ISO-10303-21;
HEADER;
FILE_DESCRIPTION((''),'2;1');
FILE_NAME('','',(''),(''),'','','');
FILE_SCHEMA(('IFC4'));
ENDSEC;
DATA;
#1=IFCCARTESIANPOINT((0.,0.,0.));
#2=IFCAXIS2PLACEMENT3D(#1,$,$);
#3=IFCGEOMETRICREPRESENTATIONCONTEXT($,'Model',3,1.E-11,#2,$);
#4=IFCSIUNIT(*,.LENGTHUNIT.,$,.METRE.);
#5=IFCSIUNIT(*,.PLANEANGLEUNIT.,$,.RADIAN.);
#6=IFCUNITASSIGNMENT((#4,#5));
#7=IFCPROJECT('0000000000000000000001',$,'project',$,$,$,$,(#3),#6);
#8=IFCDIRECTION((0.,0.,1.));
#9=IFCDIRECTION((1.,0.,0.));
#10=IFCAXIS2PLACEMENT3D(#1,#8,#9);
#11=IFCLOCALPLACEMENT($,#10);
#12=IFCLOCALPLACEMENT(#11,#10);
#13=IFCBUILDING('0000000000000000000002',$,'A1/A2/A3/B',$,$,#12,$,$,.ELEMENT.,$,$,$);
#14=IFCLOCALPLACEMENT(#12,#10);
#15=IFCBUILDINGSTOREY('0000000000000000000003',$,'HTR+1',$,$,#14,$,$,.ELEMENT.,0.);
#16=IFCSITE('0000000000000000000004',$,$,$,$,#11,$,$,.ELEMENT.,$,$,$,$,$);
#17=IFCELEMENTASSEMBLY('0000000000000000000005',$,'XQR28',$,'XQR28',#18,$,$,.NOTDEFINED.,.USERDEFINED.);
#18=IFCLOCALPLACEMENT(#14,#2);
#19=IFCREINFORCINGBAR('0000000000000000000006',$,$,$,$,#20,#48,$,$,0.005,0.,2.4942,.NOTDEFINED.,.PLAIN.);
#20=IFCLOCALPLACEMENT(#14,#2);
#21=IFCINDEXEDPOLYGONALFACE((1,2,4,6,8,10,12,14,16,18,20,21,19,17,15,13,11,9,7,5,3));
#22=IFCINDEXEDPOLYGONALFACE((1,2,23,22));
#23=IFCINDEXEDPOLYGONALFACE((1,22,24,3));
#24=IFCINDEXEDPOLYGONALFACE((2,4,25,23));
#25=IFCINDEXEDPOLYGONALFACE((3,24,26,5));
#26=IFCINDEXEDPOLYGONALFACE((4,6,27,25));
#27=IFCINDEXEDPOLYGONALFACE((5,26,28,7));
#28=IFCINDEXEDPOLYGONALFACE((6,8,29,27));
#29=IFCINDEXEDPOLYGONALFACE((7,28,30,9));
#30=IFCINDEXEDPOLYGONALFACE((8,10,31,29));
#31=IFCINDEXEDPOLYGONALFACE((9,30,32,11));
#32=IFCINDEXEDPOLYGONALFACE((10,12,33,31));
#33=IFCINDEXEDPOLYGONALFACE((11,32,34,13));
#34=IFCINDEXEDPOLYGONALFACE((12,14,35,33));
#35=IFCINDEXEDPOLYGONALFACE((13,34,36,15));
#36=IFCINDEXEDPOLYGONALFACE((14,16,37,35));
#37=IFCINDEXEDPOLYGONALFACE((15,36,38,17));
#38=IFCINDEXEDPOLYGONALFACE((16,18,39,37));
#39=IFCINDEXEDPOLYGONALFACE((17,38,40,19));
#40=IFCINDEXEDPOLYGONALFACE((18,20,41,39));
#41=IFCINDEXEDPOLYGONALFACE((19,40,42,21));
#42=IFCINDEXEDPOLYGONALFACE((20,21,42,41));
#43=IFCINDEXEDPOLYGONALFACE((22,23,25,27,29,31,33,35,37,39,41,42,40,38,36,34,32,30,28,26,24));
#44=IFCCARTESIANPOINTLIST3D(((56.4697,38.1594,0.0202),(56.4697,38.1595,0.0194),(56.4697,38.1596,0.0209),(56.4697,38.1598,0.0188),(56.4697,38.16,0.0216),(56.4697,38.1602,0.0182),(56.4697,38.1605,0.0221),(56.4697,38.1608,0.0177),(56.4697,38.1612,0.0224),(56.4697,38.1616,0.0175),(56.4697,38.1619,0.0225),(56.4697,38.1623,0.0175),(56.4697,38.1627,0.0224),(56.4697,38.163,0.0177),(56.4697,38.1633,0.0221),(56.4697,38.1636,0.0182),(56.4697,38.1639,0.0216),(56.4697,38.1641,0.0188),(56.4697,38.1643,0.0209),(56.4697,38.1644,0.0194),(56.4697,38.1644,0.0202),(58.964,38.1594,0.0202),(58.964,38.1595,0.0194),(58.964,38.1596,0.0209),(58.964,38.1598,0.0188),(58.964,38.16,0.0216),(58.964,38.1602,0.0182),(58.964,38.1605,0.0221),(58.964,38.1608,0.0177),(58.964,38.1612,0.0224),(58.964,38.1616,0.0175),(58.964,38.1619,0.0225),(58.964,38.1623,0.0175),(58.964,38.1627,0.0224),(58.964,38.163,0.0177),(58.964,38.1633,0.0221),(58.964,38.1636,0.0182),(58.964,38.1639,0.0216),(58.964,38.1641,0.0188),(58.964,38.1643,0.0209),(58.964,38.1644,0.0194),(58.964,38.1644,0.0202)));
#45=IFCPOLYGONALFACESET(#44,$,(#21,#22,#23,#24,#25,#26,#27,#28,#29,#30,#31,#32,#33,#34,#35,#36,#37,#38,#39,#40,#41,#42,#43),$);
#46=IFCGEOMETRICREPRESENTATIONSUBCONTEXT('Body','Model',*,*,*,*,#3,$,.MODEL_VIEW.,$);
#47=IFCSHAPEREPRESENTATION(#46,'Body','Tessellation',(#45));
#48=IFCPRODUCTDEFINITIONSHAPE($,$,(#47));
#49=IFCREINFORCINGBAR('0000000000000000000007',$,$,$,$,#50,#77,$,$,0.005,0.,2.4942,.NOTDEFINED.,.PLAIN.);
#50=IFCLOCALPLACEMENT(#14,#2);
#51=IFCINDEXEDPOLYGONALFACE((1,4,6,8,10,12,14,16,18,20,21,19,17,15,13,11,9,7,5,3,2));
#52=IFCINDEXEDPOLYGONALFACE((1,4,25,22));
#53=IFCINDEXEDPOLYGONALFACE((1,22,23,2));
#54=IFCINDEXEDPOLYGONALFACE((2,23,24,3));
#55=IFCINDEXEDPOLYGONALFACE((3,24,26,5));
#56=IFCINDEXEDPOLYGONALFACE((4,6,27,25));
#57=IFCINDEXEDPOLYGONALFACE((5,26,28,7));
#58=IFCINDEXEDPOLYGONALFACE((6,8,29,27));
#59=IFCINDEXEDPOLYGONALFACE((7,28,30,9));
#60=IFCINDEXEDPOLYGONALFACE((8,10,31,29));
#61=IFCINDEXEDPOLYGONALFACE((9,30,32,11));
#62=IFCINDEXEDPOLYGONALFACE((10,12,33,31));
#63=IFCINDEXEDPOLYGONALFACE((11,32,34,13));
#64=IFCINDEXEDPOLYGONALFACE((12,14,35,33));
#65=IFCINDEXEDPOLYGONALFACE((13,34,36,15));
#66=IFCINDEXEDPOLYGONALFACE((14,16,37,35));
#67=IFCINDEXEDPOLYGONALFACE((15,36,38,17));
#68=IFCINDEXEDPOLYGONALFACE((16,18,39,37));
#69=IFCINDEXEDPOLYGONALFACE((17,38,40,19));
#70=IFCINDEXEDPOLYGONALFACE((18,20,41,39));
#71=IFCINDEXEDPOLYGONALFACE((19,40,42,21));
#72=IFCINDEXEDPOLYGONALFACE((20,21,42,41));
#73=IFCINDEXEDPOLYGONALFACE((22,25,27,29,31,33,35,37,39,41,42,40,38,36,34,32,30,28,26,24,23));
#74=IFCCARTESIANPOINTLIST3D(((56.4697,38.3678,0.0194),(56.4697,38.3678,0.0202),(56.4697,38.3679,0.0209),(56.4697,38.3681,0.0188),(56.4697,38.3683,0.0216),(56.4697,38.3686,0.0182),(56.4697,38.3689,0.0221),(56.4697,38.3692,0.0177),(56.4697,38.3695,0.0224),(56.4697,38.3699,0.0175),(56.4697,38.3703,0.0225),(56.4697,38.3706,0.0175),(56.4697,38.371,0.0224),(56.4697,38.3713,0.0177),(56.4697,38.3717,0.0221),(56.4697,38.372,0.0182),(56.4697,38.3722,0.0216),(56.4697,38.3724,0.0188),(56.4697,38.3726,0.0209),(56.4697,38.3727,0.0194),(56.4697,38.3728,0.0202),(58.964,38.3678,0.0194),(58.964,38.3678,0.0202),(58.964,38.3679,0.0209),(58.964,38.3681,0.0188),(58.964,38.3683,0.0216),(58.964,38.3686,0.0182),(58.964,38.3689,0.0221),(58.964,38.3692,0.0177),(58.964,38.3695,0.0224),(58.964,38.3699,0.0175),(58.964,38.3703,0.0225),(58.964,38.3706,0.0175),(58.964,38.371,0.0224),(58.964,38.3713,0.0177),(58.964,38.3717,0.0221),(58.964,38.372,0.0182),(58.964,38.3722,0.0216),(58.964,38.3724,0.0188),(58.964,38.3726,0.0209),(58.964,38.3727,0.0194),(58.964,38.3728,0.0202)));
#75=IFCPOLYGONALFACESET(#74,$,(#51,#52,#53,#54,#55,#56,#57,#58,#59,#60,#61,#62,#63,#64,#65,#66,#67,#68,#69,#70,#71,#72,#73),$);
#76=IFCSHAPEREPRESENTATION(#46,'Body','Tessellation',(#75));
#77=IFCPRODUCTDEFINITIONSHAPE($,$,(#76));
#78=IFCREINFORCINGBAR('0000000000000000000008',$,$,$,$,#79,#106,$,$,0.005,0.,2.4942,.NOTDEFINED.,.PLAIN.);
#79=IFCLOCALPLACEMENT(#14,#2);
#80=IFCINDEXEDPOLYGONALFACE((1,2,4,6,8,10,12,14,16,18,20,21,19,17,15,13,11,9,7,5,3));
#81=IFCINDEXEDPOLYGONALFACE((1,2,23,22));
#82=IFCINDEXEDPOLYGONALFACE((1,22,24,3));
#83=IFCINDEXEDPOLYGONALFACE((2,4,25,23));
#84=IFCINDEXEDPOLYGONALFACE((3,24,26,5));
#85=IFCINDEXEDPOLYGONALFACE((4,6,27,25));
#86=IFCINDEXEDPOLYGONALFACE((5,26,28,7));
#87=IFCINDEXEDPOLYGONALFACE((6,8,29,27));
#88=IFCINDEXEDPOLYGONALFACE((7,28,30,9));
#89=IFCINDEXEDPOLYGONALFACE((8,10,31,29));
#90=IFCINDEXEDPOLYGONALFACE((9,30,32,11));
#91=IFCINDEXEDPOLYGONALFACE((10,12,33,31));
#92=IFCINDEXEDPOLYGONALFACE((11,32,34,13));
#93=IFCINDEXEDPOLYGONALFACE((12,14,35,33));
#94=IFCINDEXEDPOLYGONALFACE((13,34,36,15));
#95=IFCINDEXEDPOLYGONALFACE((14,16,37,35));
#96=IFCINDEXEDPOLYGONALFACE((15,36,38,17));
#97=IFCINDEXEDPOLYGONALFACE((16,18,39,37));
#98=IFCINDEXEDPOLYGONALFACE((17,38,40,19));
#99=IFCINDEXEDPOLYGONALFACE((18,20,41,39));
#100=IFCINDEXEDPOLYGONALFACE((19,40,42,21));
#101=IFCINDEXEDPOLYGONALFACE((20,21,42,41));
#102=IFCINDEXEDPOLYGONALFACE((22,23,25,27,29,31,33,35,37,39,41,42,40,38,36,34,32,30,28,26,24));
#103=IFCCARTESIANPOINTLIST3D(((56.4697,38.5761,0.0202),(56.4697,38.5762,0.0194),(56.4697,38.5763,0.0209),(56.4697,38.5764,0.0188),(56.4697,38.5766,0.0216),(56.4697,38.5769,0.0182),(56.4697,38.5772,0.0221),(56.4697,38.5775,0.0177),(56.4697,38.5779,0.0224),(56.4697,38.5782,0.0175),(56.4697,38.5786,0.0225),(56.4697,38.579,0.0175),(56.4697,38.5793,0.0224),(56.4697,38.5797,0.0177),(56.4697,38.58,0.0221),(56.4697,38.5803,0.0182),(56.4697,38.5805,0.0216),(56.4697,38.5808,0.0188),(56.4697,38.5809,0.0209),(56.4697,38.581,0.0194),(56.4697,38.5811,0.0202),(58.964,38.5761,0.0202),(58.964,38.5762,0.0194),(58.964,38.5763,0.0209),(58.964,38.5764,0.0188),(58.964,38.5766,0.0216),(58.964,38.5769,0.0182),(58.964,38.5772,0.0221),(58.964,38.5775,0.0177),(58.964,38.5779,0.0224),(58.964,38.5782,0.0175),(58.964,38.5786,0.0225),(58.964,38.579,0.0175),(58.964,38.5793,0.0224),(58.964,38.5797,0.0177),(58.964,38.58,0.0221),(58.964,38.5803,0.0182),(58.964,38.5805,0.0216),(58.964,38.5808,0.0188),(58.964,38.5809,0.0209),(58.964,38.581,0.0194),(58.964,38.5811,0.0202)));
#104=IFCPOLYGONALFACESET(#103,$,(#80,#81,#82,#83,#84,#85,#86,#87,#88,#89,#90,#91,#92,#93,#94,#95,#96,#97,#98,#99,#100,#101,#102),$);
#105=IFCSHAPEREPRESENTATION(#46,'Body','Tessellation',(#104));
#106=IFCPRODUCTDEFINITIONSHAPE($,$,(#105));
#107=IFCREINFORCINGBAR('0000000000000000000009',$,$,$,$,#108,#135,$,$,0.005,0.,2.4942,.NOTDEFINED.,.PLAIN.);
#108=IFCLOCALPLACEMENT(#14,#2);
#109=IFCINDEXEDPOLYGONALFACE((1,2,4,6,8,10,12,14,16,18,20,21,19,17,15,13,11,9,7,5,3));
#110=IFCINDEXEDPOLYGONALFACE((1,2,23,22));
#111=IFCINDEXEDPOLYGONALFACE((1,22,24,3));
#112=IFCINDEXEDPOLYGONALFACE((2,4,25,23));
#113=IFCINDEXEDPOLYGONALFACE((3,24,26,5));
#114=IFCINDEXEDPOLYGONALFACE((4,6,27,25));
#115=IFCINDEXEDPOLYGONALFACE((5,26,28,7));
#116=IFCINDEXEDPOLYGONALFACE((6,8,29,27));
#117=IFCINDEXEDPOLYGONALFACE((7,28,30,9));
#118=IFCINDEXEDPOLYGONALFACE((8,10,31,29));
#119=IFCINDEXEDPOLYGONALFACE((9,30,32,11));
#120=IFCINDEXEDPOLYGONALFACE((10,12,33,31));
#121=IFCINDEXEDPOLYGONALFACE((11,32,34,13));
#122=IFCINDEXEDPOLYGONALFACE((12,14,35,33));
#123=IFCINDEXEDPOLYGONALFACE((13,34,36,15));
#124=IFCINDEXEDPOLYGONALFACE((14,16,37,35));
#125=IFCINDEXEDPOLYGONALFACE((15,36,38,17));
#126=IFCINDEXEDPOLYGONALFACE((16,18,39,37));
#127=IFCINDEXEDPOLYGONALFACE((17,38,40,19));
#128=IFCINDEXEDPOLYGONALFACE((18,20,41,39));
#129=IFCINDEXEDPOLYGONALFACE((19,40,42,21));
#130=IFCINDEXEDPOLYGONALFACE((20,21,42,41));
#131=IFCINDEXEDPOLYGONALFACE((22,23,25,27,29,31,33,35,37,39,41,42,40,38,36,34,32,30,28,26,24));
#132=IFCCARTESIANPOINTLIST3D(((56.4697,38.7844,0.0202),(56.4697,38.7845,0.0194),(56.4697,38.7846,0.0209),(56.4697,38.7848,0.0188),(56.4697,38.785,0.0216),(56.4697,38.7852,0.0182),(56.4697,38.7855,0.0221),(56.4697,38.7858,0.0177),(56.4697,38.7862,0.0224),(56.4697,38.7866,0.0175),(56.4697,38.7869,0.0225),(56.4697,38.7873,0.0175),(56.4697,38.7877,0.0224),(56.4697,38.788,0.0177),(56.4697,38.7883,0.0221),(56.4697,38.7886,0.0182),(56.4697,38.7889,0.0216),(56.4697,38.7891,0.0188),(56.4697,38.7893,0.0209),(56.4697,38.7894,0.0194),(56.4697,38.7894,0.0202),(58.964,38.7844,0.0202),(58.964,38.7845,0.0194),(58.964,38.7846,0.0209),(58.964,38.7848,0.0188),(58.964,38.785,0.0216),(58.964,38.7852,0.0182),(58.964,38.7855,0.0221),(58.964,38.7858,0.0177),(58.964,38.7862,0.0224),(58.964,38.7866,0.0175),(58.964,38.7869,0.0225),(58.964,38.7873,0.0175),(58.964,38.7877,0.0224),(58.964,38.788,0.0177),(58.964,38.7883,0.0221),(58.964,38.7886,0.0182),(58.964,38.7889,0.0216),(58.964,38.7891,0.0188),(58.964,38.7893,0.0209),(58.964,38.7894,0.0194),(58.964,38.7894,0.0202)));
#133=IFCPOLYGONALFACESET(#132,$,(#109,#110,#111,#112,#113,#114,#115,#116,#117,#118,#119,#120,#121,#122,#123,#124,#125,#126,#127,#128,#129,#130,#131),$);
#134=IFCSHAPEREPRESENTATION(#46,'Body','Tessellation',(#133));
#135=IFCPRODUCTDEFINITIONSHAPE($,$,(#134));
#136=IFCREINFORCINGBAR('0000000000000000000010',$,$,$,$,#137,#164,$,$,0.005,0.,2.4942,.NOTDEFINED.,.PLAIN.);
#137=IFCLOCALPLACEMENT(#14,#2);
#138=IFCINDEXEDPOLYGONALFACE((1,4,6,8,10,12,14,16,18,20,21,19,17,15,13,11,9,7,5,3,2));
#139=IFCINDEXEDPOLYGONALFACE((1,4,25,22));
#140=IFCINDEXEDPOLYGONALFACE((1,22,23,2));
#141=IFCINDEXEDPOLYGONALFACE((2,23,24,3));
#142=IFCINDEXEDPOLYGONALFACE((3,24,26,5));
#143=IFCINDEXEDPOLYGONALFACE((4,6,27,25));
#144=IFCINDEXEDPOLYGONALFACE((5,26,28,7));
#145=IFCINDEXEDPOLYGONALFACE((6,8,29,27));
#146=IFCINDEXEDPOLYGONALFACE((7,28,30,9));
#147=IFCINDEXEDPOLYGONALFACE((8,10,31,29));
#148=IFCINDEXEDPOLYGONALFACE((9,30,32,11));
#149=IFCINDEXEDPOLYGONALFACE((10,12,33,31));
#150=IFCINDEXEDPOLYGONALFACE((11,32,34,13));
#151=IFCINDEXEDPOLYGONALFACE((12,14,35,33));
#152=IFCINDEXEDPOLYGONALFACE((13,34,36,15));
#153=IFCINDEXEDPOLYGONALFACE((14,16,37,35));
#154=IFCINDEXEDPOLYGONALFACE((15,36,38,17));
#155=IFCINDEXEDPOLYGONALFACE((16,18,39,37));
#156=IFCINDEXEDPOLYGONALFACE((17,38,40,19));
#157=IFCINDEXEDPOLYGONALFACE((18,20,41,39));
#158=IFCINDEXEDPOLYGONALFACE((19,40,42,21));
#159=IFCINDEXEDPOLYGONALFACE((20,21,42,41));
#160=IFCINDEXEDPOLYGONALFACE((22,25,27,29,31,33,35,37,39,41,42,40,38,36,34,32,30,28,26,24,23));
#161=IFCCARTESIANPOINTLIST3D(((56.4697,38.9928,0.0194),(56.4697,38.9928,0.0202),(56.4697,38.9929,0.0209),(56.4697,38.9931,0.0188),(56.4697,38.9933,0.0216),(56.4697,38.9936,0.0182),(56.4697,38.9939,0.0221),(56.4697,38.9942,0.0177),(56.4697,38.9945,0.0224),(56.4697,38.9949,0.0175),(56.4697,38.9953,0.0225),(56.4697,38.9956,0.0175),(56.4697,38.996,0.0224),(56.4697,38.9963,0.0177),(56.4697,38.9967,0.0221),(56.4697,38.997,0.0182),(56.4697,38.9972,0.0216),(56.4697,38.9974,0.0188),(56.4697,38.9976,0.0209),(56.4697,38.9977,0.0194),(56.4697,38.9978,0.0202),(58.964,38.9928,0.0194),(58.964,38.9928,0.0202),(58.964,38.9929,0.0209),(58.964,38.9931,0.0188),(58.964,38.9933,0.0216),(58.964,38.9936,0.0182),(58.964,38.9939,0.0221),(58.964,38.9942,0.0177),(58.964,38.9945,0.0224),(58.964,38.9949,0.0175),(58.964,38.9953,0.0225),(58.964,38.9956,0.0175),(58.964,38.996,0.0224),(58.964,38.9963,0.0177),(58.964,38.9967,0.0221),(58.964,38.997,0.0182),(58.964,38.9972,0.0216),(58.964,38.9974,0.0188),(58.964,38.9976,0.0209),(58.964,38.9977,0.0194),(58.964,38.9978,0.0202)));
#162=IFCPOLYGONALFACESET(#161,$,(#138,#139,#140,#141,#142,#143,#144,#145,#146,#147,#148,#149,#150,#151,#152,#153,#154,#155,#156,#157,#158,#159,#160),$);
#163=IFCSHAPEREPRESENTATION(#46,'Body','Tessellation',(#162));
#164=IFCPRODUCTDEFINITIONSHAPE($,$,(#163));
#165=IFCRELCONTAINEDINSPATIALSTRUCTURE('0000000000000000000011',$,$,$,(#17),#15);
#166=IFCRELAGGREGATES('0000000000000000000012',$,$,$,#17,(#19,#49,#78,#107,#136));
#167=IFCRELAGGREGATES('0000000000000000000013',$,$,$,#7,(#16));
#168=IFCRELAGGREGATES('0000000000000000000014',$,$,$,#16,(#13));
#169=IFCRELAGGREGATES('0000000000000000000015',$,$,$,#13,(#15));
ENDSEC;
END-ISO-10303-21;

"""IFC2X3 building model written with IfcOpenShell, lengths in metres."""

from ifc_helpers import new_model, entity, si_unit, origin, origin_with_axes, place, context, subcontext, project, spatial, shape, element, aggregate, save


model = new_model("IFC2X3")

# Units and contexts
model_context = context("Model", 3, precision=1e-11, world=origin())
body_context = subcontext(model_context, "Body", "Model", "MODEL_VIEW")
ifc_project = project(units=[si_unit("LENGTHUNIT", "METRE"), si_unit("PLANEANGLEUNIT", "RADIAN")], contexts=[model_context])

# Site, building, storey
site_placement = place(None, origin_with_axes())
site = spatial("IfcSite", under=ifc_project, at=site_placement, CompositionType="ELEMENT")
building_placement = place(site_placement, origin_with_axes())
building = spatial("IfcBuilding", under=site, at=building_placement, Name="A1/A2/A3/B", CompositionType="ELEMENT")
storey_placement = place(building_placement, origin_with_axes())
storey = spatial("IfcBuildingStorey", under=building, at=storey_placement, Name="HTR+1", CompositionType="ELEMENT", Elevation=0.0)

# Element assembly, reinforcing bars
assembly_1_placement = place(storey_placement, origin_with_axes())
assembly_1 = element("IfcElementAssembly", 1, at=assembly_1_placement, inside=storey, Name="XQR28", ObjectType="XQR28", AssemblyPlace="NOTDEFINED", PredefinedType="USERDEFINED")
reinforcing_bar_1_placement = place(assembly_1_placement, origin_with_axes())
reinforcing_bar_1 = element("IfcReinforcingBar", 2, at=reinforcing_bar_1_placement, BarLength=2.4942, BarRole="NOTDEFINED", BarSurface="PLAIN", CrossSectionArea=0.0, NominalDiameter=0.005, shapes=[
    shape(body_context, "Body", "AdvancedSweptSolid", [entity("IfcSweptDiskSolid", entity("IfcPolyline", [entity("IfcCartesianPoint", [56.4697, 38.1619, 0.02]), entity("IfcCartesianPoint", [58.964, 38.1619, 0.02])]), 0.0025, None, 0.0, 2.4942)]),
    shape(body_context, "Body", "AdvancedSweptSolid", [entity("IfcSweptDiskSolid", entity("IfcPolyline", [entity("IfcCartesianPoint", [56.4697, 38.1619, 0.02]), entity("IfcCartesianPoint", [58.964, 38.1619, 0.02])]), 0.0025, None, 0.0, 2.4942)]),
])
reinforcing_bar_2_placement = place(assembly_1_placement, origin_with_axes())
reinforcing_bar_2 = element("IfcReinforcingBar", 3, at=reinforcing_bar_2_placement, BarLength=2.4942, BarRole="NOTDEFINED", BarSurface="PLAIN", CrossSectionArea=0.0, NominalDiameter=0.005, shapes=[
    shape(body_context, "Body", "AdvancedSweptSolid", [entity("IfcSweptDiskSolid", entity("IfcPolyline", [entity("IfcCartesianPoint", [56.4697, 38.3703, 0.02]), entity("IfcCartesianPoint", [58.964, 38.3703, 0.02])]), 0.0025, None, 0.0, 2.4942)]),
    shape(body_context, "Body", "AdvancedSweptSolid", [entity("IfcSweptDiskSolid", entity("IfcPolyline", [entity("IfcCartesianPoint", [56.4697, 38.3703, 0.02]), entity("IfcCartesianPoint", [58.964, 38.3703, 0.02])]), 0.0025, None, 0.0, 2.4942)]),
])
reinforcing_bar_3_placement = place(assembly_1_placement, origin_with_axes())
reinforcing_bar_3 = element("IfcReinforcingBar", 4, at=reinforcing_bar_3_placement, BarLength=2.4942, BarRole="NOTDEFINED", BarSurface="PLAIN", CrossSectionArea=0.0, NominalDiameter=0.005, shapes=[
    shape(body_context, "Body", "AdvancedSweptSolid", [entity("IfcSweptDiskSolid", entity("IfcPolyline", [entity("IfcCartesianPoint", [56.4697, 38.5786, 0.02]), entity("IfcCartesianPoint", [58.964, 38.5786, 0.02])]), 0.0025, None, 0.0, 2.4942)]),
    shape(body_context, "Body", "AdvancedSweptSolid", [entity("IfcSweptDiskSolid", entity("IfcPolyline", [entity("IfcCartesianPoint", [56.4697, 38.5786, 0.02]), entity("IfcCartesianPoint", [58.964, 38.5786, 0.02])]), 0.0025, None, 0.0, 2.4942)]),
])
reinforcing_bar_4_placement = place(assembly_1_placement, origin_with_axes())
reinforcing_bar_4 = element("IfcReinforcingBar", 5, at=reinforcing_bar_4_placement, BarLength=2.4942, BarRole="NOTDEFINED", BarSurface="PLAIN", CrossSectionArea=0.0, NominalDiameter=0.005, shapes=[
    shape(body_context, "Body", "AdvancedSweptSolid", [entity("IfcSweptDiskSolid", entity("IfcPolyline", [entity("IfcCartesianPoint", [56.4697, 38.7869, 0.02]), entity("IfcCartesianPoint", [58.964, 38.7869, 0.02])]), 0.0025, None, 0.0, 2.4942)]),
    shape(body_context, "Body", "AdvancedSweptSolid", [entity("IfcSweptDiskSolid", entity("IfcPolyline", [entity("IfcCartesianPoint", [56.4697, 38.7869, 0.02]), entity("IfcCartesianPoint", [58.964, 38.7869, 0.02])]), 0.0025, None, 0.0, 2.4942)]),
])
reinforcing_bar_5_placement = place(assembly_1_placement, origin_with_axes())
reinforcing_bar_5 = element("IfcReinforcingBar", 6, at=reinforcing_bar_5_placement, BarLength=2.4942, BarRole="NOTDEFINED", BarSurface="PLAIN", CrossSectionArea=0.0, NominalDiameter=0.005, shapes=[
    shape(body_context, "Body", "AdvancedSweptSolid", [entity("IfcSweptDiskSolid", entity("IfcPolyline", [entity("IfcCartesianPoint", [56.4697, 38.9953, 0.02]), entity("IfcCartesianPoint", [58.964, 38.9953, 0.02])]), 0.0025, None, 0.0, 2.4942)]),
    shape(body_context, "Body", "AdvancedSweptSolid", [entity("IfcSweptDiskSolid", entity("IfcPolyline", [entity("IfcCartesianPoint", [56.4697, 38.9953, 0.02]), entity("IfcCartesianPoint", [58.964, 38.9953, 0.02])]), 0.0025, None, 0.0, 2.4942)]),
])
aggregate(assembly_1, [reinforcing_bar_1, reinforcing_bar_2, reinforcing_bar_3, reinforcing_bar_4, reinforcing_bar_5])

save(model, "model.ifc")
